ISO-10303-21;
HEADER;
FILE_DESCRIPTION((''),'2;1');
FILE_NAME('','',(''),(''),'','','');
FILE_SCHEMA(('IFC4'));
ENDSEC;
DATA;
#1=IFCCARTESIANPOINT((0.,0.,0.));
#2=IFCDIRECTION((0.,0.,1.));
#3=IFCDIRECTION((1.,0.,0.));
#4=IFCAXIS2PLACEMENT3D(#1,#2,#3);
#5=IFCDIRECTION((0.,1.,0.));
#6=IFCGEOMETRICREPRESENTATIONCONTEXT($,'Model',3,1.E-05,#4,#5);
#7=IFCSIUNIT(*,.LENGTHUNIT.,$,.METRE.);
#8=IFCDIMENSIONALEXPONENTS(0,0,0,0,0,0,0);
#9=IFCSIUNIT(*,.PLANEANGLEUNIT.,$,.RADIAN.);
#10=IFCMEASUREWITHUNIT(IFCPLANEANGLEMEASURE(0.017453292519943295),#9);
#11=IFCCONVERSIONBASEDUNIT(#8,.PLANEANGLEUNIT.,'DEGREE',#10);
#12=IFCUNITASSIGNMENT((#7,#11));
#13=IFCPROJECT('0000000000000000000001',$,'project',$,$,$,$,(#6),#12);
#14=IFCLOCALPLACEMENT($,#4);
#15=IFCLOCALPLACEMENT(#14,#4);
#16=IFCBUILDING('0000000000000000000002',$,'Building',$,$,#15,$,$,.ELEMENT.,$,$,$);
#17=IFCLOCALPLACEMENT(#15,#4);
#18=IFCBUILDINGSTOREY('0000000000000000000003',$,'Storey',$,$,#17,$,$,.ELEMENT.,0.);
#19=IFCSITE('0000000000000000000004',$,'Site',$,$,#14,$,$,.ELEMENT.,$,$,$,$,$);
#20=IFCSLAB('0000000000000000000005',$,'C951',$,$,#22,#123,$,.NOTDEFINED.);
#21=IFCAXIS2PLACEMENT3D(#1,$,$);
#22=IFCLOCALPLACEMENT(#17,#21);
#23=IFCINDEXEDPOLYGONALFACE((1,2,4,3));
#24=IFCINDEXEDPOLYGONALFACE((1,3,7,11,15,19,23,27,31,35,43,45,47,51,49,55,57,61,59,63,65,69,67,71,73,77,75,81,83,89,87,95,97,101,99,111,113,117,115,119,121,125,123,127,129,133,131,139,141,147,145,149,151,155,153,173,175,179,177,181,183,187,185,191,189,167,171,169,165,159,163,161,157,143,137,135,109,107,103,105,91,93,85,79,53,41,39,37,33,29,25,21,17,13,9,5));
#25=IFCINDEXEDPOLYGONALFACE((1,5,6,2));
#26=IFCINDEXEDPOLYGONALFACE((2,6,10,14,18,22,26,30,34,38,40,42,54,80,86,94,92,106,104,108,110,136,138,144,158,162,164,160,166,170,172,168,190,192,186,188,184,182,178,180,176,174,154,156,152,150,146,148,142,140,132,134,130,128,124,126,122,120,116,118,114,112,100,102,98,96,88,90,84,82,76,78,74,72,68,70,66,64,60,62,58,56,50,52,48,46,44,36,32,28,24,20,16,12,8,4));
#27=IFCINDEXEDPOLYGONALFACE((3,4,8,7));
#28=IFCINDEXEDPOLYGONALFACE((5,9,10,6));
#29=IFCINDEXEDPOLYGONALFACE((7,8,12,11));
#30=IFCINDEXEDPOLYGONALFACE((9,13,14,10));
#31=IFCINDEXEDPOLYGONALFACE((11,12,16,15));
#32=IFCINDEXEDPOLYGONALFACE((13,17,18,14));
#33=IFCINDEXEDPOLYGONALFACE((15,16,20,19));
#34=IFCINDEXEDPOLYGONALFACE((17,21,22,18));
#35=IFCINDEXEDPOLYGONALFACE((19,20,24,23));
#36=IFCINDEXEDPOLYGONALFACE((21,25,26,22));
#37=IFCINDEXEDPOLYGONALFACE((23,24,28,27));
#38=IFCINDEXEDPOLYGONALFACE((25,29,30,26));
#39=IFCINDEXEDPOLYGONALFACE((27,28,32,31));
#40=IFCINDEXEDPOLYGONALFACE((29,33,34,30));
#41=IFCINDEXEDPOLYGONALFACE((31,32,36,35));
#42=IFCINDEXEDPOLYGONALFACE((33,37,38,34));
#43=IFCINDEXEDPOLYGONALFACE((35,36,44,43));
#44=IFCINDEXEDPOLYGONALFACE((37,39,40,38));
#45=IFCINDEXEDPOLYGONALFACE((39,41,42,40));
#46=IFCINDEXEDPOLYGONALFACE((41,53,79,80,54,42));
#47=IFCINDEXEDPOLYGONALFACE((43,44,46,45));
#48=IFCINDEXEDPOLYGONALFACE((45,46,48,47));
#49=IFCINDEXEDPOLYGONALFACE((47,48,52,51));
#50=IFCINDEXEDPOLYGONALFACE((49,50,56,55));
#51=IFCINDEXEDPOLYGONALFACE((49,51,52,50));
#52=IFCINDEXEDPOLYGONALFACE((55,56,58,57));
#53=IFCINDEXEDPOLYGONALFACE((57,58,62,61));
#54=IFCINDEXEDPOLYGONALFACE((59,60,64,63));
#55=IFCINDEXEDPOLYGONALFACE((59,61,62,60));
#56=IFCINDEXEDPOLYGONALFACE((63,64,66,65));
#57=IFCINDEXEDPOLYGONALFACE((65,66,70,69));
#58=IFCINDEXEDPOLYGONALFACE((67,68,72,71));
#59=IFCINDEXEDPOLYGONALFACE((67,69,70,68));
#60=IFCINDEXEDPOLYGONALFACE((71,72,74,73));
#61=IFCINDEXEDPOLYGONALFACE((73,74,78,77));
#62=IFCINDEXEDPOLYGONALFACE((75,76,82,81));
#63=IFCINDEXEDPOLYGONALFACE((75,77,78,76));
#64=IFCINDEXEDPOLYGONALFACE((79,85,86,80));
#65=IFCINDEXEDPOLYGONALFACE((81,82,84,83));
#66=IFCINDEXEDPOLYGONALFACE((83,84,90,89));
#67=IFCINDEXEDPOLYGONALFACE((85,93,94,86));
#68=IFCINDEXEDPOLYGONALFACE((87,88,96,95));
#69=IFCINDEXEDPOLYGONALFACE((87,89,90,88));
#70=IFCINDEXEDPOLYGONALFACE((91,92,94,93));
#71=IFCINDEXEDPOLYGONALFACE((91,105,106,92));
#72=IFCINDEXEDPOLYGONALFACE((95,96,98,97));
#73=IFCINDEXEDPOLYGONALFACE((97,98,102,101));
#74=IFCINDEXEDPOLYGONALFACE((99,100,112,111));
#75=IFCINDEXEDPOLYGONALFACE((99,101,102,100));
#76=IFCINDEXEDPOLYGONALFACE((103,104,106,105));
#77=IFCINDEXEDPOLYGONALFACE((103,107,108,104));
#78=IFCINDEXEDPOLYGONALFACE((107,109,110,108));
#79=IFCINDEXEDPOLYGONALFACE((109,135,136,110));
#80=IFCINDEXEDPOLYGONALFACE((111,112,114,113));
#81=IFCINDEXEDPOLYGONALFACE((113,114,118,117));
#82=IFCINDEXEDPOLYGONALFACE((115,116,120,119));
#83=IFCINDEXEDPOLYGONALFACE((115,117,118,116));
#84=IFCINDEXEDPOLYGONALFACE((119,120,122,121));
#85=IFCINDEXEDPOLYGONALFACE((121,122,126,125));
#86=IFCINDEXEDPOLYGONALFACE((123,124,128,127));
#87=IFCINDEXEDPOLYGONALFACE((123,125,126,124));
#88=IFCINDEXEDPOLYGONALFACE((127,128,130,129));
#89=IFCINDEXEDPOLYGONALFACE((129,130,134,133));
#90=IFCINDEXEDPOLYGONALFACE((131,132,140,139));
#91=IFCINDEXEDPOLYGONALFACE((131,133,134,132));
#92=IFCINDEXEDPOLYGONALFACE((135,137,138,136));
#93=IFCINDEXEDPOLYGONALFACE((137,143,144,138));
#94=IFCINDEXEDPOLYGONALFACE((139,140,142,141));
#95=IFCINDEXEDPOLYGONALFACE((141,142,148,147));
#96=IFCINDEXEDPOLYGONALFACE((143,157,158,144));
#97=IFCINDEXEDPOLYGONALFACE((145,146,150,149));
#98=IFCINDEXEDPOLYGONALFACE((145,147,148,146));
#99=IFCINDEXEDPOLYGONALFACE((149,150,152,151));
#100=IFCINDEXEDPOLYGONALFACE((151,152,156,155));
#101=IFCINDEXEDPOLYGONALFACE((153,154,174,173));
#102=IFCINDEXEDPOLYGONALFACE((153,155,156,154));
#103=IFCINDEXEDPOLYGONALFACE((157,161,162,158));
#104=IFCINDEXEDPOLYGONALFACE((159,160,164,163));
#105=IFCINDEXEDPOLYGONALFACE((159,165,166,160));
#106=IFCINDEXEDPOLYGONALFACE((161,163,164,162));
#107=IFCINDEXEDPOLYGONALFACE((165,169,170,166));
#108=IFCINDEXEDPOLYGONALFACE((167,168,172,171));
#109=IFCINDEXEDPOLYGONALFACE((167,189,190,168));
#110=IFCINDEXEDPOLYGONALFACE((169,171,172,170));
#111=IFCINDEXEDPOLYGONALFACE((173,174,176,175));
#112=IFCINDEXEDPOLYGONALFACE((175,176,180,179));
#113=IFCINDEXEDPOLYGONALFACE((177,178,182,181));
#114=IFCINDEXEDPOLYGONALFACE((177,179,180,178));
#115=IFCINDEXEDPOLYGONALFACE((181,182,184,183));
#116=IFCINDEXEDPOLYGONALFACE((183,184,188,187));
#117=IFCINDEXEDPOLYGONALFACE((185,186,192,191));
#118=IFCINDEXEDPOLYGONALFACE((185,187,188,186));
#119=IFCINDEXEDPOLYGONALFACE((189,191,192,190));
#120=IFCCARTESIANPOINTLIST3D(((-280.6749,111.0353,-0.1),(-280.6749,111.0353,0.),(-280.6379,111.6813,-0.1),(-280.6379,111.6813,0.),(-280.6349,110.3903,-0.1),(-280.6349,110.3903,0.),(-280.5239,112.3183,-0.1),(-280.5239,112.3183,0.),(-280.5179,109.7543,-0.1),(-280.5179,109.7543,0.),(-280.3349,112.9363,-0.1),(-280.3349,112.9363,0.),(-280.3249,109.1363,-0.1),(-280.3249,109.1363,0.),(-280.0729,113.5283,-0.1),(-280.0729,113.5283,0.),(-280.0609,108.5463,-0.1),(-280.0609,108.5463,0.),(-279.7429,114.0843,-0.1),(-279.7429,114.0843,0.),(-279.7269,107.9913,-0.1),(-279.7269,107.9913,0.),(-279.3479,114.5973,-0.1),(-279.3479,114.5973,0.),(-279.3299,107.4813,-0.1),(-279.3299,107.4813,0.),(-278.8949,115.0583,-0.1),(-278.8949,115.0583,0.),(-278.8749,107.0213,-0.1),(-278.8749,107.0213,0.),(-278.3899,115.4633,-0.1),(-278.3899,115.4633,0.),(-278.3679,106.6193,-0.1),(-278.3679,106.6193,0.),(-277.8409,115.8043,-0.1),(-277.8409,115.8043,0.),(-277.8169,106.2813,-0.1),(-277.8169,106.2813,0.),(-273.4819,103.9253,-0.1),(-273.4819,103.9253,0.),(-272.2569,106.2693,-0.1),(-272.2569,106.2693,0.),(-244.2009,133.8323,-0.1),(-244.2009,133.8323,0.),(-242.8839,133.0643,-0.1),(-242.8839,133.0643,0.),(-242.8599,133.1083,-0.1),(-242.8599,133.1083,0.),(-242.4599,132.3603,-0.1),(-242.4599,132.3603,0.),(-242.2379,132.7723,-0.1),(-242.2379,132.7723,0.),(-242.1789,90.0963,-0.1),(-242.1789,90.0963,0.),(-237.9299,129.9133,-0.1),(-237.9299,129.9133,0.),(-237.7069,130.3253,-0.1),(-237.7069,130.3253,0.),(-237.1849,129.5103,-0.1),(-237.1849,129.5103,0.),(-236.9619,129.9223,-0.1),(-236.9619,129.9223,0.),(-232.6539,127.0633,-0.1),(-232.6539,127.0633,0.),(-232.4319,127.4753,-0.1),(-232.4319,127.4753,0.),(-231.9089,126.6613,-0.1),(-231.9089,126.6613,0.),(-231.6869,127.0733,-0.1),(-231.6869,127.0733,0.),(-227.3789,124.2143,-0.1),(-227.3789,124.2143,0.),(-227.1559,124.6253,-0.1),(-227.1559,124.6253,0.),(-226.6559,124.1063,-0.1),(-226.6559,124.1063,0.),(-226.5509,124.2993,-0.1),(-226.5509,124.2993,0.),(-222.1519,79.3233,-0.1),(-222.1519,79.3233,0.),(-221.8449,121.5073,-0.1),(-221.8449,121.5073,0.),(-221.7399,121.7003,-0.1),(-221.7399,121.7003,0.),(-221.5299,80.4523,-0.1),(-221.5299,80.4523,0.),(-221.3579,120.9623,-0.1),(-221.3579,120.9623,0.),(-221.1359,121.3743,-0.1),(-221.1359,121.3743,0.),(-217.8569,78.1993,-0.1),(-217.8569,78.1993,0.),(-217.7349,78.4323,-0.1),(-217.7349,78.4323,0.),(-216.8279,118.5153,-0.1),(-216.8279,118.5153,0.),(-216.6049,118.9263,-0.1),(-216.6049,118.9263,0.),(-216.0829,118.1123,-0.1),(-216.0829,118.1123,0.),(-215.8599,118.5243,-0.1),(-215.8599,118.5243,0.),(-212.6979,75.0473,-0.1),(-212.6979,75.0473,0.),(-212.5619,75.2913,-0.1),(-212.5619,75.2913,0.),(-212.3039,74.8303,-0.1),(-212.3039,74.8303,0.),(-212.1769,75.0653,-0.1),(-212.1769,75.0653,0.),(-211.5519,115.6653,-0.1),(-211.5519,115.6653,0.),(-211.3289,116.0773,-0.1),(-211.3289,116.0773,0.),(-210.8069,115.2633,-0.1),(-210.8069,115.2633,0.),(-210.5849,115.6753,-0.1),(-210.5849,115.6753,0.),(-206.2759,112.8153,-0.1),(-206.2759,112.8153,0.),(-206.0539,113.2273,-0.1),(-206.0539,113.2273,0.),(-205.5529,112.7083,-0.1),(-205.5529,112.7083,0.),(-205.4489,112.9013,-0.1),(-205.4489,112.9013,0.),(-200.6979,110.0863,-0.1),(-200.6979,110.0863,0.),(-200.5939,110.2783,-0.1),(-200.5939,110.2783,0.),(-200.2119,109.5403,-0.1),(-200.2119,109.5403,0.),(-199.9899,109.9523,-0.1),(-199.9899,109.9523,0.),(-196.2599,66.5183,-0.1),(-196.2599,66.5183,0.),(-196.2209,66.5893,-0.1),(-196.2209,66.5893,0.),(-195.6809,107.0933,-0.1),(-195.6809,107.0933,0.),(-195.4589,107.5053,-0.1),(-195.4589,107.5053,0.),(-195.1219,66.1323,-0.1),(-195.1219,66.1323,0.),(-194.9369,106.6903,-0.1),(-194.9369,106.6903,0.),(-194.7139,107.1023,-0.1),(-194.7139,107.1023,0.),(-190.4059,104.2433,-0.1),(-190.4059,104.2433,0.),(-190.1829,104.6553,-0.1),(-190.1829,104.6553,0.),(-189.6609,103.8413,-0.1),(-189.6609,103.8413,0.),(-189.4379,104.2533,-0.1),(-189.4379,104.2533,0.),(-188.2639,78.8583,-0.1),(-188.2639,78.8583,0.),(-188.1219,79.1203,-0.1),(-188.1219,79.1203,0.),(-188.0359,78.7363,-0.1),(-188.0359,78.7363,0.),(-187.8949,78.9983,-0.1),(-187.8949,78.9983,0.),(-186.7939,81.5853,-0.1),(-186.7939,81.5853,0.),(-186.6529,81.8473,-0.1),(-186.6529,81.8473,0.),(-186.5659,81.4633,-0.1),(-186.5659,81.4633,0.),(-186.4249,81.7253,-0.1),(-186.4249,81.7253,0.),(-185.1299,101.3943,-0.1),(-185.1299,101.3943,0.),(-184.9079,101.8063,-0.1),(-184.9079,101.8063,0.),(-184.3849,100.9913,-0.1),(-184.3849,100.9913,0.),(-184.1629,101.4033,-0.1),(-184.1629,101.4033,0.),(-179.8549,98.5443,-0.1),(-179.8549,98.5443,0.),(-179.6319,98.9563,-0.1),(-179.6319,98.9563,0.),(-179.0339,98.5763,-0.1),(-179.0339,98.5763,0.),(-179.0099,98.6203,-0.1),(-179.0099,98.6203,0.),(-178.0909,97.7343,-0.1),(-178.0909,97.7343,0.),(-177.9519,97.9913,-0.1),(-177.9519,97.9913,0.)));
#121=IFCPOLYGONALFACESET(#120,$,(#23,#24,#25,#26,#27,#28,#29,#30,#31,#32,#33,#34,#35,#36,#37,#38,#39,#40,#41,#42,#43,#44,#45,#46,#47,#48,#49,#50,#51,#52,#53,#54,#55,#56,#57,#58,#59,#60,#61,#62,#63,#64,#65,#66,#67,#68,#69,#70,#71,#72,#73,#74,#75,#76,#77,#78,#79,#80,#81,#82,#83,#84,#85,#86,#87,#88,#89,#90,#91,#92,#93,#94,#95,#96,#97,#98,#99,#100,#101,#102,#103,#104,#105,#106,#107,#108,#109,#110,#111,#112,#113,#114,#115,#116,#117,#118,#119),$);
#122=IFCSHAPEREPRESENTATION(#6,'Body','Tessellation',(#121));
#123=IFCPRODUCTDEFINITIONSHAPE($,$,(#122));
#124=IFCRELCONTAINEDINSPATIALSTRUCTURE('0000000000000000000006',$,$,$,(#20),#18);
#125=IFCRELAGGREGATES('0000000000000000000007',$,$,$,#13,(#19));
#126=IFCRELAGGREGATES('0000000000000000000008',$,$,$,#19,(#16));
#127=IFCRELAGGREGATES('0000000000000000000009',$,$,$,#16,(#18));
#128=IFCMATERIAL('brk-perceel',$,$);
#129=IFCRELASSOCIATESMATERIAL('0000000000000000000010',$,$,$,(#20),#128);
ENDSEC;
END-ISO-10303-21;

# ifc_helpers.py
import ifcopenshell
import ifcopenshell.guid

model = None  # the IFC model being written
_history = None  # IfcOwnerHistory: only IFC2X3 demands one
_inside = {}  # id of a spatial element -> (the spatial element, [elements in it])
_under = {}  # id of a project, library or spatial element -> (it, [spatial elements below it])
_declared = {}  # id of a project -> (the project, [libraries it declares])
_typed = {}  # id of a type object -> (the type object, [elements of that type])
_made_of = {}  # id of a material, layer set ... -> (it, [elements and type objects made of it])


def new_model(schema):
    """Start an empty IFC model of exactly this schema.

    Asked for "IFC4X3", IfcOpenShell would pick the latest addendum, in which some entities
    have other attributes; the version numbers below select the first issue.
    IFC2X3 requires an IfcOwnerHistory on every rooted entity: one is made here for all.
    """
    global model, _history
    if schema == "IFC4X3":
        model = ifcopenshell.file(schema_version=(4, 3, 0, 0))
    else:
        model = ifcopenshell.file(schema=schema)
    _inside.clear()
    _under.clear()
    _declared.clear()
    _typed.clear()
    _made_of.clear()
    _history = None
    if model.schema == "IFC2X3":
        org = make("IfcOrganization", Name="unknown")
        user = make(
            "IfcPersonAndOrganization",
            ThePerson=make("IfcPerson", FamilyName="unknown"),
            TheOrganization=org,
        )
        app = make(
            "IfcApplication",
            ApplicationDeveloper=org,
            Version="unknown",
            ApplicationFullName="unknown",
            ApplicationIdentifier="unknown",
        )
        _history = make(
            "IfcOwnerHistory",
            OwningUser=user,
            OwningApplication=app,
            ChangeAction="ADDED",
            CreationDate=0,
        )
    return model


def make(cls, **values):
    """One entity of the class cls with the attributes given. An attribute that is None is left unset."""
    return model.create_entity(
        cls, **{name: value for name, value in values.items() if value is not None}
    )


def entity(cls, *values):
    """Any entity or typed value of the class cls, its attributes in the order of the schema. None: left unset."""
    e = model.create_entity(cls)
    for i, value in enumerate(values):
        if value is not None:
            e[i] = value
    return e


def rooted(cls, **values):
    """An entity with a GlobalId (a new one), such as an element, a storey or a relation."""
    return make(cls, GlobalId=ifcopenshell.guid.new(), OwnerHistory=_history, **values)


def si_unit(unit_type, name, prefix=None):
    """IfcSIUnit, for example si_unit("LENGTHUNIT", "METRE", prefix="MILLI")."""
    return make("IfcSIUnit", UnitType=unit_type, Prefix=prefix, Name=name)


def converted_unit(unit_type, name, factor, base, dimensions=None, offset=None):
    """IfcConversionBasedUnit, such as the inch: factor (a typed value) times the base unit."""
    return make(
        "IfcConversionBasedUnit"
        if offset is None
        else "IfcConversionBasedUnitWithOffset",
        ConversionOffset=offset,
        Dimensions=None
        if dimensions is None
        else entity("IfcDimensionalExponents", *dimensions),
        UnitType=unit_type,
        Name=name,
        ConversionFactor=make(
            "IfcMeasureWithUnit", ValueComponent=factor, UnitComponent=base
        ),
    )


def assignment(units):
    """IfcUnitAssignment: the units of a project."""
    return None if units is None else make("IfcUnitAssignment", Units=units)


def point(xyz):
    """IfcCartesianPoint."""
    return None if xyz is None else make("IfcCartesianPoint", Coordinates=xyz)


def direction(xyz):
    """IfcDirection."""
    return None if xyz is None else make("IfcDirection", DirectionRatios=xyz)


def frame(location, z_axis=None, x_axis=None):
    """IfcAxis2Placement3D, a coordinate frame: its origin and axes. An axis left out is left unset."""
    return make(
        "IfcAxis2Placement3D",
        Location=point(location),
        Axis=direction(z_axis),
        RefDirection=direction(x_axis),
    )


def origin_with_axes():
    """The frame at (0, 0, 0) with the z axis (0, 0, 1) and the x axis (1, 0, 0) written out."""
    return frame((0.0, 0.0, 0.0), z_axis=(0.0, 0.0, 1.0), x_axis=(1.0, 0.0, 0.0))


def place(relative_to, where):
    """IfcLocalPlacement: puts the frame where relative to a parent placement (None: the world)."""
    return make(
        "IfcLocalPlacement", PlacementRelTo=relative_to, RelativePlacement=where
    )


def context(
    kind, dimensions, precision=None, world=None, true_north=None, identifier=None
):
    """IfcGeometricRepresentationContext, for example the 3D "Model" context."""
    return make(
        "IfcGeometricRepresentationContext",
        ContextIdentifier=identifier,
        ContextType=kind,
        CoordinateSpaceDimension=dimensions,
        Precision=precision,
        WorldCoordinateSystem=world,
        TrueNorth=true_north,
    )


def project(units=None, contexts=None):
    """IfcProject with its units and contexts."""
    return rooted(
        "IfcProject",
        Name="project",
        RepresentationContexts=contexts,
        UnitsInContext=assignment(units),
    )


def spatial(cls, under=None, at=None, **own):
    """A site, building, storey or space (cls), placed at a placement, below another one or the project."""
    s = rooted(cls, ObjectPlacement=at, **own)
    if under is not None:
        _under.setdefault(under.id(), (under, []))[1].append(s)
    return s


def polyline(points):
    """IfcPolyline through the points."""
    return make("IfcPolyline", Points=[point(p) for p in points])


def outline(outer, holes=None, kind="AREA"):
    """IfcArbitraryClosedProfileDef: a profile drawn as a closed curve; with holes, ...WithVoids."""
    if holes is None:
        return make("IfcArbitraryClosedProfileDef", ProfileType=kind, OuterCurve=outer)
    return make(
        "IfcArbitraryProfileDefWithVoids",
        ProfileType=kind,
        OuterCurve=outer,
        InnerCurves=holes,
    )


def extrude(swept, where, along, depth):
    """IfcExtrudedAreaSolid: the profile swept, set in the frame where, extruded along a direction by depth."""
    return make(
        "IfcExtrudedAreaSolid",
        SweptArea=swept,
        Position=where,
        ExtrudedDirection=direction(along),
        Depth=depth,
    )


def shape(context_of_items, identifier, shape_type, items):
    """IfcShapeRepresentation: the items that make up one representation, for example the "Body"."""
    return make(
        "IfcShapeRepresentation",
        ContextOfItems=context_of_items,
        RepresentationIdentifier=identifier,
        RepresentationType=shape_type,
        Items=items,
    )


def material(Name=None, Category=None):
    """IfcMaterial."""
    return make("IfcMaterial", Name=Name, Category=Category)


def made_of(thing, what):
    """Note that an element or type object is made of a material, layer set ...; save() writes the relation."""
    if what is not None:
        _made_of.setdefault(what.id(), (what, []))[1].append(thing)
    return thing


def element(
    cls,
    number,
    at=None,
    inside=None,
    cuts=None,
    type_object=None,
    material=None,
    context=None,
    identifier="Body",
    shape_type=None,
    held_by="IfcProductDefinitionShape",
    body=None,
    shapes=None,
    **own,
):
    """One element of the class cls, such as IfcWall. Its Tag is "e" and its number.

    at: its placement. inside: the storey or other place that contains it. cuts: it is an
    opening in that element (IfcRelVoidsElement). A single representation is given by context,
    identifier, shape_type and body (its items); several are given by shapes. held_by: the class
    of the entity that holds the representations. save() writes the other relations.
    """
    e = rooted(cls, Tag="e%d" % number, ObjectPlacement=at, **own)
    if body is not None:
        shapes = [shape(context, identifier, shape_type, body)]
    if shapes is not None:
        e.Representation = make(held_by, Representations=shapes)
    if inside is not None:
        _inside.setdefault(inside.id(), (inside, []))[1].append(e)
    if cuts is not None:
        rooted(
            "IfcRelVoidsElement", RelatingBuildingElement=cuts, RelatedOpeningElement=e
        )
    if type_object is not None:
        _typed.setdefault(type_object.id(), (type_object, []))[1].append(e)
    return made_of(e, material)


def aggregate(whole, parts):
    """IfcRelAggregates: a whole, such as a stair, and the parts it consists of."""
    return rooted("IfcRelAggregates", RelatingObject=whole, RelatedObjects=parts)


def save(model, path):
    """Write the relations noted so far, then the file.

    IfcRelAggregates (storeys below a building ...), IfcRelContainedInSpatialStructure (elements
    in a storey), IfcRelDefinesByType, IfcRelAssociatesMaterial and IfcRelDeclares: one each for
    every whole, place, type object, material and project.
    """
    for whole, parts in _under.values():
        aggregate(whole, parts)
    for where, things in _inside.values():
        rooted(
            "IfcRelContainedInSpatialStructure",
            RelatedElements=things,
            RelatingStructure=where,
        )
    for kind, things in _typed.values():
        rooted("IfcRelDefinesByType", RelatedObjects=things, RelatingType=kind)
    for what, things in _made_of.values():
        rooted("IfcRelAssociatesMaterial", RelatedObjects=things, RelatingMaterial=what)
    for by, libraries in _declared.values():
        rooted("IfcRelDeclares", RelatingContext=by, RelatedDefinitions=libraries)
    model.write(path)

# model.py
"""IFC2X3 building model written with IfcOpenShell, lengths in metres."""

from ifc_helpers import new_model, entity, si_unit, converted_unit, direction, frame, origin_with_axes, place, context, project, spatial, polyline, outline, extrude, material, element, save


model = new_model("IFC2X3")

# Units and contexts
model_context = context("Model", 3, precision=1e-05, world=origin_with_axes(), true_north=direction((0.0, 1.0, 0.0)))
ifc_project = project(units=[si_unit("LENGTHUNIT", "METRE"), converted_unit("PLANEANGLEUNIT", "DEGREE", entity("IfcPlaneAngleMeasure", 0.017453292519943295), si_unit("PLANEANGLEUNIT", "RADIAN"), dimensions=[0, 0, 0, 0, 0, 0, 0])], contexts=[model_context])

# Site, building, storey
site_placement = place(None, origin_with_axes())
site = spatial("IfcSite", under=ifc_project, at=site_placement, Name="Site", CompositionType="ELEMENT")
building_placement = place(site_placement, origin_with_axes())
building = spatial("IfcBuilding", under=site, at=building_placement, Name="Building", CompositionType="ELEMENT")
storey_placement = place(building_placement, origin_with_axes())
storey = spatial("IfcBuildingStorey", under=building, at=storey_placement, Name="Storey", CompositionType="ELEMENT", Elevation=0.0)

# Slab
ifc_material = material(Name="brk-perceel")
slab_1_placement = place(storey_placement, frame((0.0, 0.0, -0.1), z_axis=(0.0, 0.0, 1.0), x_axis=(1.0, 0.0, 0.0)))
element("IfcSlab", 1, at=slab_1_placement, inside=storey, material=ifc_material, Name="C951", PredefinedType="NOTDEFINED", context=model_context, shape_type="SweptSolid", body=[
    extrude(outline(polyline([(-278.3679, 106.6193), (-278.8749, 107.0213), (-279.3299, 107.4813), (-279.7269, 107.9913), (-280.0609, 108.5463), (-280.3249, 109.1363), (-280.5179, 109.7543), (-280.6349, 110.3903), (-280.6749, 111.0353), (-280.6379, 111.6813), (-280.5239, 112.3183), (-280.3349, 112.9363), (-280.0729, 113.5283), (-279.7429, 114.0843), (-279.3479, 114.5973), (-278.8949, 115.0583), (-278.3899, 115.4633), (-277.8409, 115.8043), (-244.2009, 133.8323), (-242.8839, 133.0643), (-242.8599, 133.1083), (-242.2379, 132.7723), (-242.4599, 132.3603), (-237.9299, 129.9133), (-237.7069, 130.3253), (-236.9619, 129.9223), (-237.1849, 129.5103), (-232.6539, 127.0633), (-232.4319, 127.4753), (-231.6869, 127.0733), (-231.9089, 126.6613), (-227.3789, 124.2143), (-227.1559, 124.6253), (-226.5509, 124.2993), (-226.6559, 124.1063), (-221.8449, 121.5073), (-221.7399, 121.7003), (-221.1359, 121.3743), (-221.3579, 120.9623), (-216.8279, 118.5153), (-216.6049, 118.9263), (-215.8599, 118.5243), (-216.0829, 118.1123), (-211.5519, 115.6653), (-211.3289, 116.0773), (-210.5849, 115.6753), (-210.8069, 115.2633), (-206.2759, 112.8153), (-206.0539, 113.2273), (-205.4489, 112.9013), (-205.5529, 112.7083), (-200.6979, 110.0863), (-200.5939, 110.2783), (-199.9899, 109.9523), (-200.2119, 109.5403), (-195.6809, 107.0933), (-195.4589, 107.5053), (-194.7139, 107.1023), (-194.9369, 106.6903), (-190.4059, 104.2433), (-190.1829, 104.6553), (-189.4379, 104.2533), (-189.6609, 103.8413), (-185.1299, 101.3943), (-184.9079, 101.8063), (-184.1629, 101.4033), (-184.3849, 100.9913), (-179.8549, 98.5443), (-179.6319, 98.9563), (-179.0099, 98.6203), (-179.0339, 98.5763), (-177.9519, 97.9913), (-178.0909, 97.7343), (-186.6529, 81.8473), (-186.4249, 81.7253), (-186.5659, 81.4633), (-186.7939, 81.5853), (-188.1219, 79.1203), (-187.8949, 78.9983), (-188.0359, 78.7363), (-188.2639, 78.8583), (-195.1219, 66.1323), (-196.2209, 66.5893), (-196.2599, 66.5183), (-212.1769, 75.0653), (-212.3039, 74.8303), (-212.6979, 75.0473), (-212.5619, 75.2913), (-217.8569, 78.1993), (-217.7349, 78.4323), (-221.5299, 80.4523), (-222.1519, 79.3233), (-242.1789, 90.0963), (-272.2569, 106.2693), (-273.4819, 103.9253), (-277.8169, 106.2813), (-278.3679, 106.6193)])), origin_with_axes(), (0.0, 0.0, 1.0), 0.1),
])

save(model, "model.ifc")
